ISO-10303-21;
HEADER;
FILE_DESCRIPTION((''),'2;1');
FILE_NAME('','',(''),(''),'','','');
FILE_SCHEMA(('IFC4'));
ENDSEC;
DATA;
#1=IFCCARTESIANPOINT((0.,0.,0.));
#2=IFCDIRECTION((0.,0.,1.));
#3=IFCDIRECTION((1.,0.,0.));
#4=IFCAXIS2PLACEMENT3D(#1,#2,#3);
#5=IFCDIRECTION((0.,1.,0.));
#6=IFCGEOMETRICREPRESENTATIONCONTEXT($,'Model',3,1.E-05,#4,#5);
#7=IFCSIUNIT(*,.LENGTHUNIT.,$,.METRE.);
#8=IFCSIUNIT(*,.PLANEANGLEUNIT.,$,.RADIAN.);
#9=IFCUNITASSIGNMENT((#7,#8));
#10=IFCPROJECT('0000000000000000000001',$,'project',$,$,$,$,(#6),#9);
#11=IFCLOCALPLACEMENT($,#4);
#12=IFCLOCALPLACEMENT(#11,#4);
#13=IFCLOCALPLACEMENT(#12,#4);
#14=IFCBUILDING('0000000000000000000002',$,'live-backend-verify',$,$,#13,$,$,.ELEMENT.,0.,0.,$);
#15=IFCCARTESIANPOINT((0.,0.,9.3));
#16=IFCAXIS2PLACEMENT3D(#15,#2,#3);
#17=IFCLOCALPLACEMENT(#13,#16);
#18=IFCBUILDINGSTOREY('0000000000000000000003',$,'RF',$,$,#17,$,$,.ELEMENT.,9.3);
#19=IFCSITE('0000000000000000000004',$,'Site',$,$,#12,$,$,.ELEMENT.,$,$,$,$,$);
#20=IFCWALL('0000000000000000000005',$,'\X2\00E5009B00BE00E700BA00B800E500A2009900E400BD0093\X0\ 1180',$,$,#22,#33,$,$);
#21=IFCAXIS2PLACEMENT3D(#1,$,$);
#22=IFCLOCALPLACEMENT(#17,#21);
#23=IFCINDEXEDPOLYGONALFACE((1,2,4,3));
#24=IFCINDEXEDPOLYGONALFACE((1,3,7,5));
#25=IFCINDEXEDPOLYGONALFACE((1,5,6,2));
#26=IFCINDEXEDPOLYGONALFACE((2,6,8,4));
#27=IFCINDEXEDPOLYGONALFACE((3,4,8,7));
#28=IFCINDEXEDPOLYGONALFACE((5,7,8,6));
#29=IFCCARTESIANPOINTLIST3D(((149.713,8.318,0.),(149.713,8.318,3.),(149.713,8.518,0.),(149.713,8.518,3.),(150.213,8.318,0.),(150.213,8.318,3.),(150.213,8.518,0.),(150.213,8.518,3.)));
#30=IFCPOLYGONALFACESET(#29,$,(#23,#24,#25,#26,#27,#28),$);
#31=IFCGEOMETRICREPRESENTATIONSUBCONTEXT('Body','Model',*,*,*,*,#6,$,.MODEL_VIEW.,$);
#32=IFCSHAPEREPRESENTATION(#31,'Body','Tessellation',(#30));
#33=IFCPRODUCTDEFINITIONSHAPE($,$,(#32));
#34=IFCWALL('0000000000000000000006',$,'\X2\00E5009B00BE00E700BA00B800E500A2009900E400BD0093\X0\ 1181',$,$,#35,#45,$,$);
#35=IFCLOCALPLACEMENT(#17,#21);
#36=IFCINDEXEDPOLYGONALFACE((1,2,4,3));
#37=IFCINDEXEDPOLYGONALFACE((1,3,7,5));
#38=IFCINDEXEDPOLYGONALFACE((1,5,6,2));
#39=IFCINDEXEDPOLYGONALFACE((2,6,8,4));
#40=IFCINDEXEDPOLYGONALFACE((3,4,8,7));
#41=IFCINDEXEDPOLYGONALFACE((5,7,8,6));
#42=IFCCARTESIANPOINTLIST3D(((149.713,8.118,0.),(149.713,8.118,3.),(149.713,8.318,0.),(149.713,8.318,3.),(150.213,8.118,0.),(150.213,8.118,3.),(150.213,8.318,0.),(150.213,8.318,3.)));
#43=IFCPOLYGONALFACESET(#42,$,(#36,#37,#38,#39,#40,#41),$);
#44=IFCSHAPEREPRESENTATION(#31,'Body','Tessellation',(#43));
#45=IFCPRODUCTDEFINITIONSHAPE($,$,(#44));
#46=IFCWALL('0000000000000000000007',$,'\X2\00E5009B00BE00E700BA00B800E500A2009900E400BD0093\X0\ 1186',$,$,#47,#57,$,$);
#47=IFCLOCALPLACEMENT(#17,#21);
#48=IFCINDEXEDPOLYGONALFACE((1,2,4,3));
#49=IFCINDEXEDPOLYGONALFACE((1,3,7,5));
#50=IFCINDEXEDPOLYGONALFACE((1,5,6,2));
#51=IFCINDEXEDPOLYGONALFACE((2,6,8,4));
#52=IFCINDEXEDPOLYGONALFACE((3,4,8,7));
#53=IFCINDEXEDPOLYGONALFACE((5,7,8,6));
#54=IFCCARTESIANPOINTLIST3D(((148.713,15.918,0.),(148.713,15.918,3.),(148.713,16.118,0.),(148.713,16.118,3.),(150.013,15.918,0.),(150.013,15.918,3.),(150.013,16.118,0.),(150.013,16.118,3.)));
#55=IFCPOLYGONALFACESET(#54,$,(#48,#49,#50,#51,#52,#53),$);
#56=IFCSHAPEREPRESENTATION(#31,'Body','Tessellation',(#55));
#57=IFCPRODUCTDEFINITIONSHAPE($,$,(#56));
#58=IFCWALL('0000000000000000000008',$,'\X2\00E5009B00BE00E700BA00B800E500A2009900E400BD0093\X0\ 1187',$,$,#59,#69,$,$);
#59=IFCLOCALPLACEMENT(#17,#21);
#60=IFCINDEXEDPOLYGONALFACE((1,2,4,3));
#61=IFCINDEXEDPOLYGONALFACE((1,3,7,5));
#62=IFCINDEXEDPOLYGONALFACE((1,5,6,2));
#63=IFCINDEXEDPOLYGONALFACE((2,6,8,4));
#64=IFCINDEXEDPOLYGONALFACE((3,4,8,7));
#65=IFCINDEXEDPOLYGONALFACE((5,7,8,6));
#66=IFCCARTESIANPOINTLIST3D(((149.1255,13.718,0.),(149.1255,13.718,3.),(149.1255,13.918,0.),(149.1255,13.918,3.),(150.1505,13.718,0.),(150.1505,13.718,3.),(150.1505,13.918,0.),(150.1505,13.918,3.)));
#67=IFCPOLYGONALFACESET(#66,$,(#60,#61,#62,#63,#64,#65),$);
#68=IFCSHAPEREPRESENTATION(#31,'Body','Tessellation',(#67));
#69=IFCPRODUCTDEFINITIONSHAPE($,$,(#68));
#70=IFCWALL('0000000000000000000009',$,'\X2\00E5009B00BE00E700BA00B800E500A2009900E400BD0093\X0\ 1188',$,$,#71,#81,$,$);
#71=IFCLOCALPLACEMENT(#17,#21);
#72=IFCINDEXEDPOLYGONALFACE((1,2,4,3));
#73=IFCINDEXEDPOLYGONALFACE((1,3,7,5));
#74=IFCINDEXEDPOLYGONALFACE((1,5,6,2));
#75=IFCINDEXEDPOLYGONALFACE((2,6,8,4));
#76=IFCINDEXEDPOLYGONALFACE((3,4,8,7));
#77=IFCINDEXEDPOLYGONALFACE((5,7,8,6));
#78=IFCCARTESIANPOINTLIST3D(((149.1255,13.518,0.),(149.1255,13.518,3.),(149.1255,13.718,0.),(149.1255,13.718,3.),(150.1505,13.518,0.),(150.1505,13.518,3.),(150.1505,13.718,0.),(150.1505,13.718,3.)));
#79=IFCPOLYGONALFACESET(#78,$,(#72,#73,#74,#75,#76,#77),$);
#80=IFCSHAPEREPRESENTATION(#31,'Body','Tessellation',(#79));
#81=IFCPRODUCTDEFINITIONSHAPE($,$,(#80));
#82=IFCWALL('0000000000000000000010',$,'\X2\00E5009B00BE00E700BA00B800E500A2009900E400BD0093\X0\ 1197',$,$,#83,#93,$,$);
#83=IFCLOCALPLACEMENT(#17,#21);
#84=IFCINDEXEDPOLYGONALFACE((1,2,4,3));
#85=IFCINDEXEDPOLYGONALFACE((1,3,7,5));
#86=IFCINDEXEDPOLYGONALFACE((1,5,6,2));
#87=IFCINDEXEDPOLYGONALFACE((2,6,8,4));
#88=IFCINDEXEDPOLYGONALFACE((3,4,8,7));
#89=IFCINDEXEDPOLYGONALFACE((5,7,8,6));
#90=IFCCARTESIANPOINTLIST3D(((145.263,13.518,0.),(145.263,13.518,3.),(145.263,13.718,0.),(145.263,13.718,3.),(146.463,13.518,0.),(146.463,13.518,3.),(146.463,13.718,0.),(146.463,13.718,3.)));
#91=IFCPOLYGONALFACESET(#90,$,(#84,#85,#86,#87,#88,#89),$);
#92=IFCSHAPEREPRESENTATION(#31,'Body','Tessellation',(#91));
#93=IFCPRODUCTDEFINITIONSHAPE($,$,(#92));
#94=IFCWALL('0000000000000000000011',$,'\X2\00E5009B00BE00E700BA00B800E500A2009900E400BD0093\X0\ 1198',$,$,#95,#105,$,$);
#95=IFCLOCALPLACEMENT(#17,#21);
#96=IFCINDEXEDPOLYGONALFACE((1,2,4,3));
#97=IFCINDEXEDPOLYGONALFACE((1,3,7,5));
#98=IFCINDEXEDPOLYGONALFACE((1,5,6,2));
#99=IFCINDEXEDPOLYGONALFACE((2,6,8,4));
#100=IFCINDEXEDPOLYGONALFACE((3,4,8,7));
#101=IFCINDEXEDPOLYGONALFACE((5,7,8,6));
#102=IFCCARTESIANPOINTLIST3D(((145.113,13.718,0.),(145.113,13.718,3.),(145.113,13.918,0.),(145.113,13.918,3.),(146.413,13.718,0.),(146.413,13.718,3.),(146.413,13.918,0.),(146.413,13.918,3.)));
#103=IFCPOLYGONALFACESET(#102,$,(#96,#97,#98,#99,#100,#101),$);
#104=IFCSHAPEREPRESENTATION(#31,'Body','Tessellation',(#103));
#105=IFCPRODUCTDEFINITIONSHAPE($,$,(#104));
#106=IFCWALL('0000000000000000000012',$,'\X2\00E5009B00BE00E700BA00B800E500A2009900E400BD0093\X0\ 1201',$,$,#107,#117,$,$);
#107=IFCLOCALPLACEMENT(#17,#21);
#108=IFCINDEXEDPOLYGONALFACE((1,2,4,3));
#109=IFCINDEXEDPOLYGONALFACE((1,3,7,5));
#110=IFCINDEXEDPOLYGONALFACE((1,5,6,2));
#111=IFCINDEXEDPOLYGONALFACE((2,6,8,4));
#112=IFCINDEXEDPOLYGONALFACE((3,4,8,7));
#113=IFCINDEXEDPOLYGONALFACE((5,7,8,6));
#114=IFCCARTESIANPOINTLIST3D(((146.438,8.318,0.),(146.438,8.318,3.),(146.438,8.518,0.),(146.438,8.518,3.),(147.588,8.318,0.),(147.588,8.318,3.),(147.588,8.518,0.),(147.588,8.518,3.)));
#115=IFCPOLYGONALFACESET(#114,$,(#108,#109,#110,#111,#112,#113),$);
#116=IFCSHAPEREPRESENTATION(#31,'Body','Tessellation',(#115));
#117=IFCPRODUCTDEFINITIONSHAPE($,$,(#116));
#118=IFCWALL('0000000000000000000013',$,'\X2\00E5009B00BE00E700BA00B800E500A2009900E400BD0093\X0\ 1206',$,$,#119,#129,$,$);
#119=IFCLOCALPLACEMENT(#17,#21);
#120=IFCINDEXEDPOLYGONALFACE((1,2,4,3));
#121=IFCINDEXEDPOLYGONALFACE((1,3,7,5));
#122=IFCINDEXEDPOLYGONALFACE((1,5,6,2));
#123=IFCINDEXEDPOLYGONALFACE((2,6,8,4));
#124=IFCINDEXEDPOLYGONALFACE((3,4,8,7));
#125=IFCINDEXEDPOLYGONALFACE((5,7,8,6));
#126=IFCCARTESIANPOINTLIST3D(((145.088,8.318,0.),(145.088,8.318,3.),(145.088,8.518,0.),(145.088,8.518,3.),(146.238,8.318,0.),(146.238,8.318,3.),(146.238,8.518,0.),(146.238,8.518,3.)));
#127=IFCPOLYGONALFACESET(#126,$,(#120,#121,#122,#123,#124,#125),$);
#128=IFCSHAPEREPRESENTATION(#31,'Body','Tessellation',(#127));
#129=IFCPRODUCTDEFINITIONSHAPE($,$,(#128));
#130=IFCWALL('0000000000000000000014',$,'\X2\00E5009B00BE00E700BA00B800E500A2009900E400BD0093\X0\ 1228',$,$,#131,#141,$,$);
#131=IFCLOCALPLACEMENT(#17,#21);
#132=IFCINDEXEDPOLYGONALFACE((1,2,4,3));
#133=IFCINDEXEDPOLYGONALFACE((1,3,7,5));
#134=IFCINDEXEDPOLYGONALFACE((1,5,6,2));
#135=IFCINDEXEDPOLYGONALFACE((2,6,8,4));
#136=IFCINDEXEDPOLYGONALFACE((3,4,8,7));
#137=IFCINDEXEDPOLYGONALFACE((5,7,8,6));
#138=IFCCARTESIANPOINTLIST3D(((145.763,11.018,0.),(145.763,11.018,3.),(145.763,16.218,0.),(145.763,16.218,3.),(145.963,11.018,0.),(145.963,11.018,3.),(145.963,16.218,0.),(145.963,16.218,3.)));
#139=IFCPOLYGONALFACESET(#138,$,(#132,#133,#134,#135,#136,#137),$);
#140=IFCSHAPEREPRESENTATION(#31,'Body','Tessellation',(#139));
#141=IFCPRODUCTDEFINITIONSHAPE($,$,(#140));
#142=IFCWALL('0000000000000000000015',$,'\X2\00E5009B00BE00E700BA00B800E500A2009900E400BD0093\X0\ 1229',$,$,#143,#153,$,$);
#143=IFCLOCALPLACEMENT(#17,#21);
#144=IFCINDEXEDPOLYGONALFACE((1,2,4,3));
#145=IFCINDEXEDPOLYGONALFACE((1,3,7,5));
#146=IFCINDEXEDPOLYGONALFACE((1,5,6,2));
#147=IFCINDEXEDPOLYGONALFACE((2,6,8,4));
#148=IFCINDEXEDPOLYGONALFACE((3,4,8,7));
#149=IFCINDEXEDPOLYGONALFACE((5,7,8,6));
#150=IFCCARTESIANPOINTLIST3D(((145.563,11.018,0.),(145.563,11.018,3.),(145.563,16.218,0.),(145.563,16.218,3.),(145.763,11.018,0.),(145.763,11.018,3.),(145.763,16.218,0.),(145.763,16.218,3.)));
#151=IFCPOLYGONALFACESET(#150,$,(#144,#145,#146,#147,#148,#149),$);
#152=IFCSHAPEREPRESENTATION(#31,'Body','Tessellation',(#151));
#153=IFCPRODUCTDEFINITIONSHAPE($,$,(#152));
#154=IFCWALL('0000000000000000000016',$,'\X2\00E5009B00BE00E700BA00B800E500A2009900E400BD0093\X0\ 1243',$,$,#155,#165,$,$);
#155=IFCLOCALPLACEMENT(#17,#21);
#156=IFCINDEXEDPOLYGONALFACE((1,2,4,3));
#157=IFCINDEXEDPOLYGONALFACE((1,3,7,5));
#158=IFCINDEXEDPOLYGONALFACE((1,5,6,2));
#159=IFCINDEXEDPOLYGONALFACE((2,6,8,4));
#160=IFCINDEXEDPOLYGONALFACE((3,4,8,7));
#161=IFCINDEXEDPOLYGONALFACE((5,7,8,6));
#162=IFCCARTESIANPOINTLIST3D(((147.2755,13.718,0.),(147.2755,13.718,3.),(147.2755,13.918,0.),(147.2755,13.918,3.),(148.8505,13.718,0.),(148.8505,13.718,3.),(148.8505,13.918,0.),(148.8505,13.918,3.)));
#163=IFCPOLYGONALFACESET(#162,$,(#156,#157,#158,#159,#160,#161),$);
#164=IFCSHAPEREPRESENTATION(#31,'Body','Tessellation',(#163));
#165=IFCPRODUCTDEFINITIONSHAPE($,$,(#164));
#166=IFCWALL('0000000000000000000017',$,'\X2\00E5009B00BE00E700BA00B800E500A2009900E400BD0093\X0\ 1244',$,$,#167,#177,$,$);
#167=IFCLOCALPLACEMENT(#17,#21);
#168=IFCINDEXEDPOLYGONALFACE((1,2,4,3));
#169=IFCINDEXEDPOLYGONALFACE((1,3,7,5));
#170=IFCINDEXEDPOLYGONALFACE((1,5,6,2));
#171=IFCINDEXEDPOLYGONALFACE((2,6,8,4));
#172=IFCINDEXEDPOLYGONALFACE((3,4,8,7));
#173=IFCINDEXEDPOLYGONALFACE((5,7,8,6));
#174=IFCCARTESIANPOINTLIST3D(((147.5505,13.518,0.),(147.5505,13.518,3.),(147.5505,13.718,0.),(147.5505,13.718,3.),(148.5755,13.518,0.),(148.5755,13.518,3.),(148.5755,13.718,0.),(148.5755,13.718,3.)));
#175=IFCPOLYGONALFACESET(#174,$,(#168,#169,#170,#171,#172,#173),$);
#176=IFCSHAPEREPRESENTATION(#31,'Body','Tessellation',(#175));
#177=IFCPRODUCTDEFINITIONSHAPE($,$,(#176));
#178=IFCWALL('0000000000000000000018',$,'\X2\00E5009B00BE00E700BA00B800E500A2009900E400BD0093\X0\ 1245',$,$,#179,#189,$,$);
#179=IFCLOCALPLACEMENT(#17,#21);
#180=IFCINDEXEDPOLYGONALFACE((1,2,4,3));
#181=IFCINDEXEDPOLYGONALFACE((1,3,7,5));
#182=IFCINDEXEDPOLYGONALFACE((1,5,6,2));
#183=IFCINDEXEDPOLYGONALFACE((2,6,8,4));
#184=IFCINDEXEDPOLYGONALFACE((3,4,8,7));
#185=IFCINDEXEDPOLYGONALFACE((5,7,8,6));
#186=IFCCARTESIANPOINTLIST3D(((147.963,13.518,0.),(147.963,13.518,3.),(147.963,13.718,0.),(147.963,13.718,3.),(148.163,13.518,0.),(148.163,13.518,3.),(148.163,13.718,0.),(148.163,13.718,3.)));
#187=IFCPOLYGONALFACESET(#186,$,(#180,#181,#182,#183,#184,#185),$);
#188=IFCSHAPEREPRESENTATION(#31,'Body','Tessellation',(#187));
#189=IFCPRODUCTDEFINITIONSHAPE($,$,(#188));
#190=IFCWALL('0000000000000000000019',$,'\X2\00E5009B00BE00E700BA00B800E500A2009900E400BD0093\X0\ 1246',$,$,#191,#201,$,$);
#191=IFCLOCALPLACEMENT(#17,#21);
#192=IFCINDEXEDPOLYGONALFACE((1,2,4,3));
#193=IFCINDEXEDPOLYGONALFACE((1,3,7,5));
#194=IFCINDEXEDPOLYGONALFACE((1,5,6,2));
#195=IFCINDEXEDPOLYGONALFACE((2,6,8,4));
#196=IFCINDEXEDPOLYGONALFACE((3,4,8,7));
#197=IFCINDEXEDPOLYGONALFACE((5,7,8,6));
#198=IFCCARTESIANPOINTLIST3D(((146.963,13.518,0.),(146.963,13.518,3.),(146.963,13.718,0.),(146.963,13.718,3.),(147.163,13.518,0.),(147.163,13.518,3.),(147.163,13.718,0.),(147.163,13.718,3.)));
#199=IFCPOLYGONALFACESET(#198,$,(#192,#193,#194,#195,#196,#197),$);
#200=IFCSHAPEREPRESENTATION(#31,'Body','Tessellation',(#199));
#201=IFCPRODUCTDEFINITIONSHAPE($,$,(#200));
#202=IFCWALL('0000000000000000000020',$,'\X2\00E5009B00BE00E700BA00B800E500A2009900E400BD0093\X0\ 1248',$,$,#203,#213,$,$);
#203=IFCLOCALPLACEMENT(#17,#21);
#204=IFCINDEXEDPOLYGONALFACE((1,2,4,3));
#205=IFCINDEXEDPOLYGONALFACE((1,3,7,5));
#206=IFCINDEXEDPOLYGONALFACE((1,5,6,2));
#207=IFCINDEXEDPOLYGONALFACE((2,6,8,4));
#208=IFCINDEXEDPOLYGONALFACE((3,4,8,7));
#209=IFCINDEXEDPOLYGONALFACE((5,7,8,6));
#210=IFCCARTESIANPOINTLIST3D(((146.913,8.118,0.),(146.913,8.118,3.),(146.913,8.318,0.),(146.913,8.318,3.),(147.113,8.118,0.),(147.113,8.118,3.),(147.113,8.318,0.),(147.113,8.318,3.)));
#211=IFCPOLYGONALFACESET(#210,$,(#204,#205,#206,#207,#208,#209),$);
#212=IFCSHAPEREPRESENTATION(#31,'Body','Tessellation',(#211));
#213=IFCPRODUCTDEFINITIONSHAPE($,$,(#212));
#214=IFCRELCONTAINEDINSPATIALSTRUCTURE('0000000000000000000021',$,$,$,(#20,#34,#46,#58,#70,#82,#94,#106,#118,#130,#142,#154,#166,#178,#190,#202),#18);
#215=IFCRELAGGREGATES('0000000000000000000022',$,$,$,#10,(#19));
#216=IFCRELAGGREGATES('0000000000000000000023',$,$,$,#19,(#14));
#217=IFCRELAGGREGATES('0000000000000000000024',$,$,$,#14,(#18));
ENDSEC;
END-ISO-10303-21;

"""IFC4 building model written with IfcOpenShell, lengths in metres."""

from ifc_helpers import new_model, si_unit, direction, frame, frame_2d, origin_with_axes, place, context, subcontext, project, spatial, rectangle, extrude, element, save


model = new_model("IFC4")

# Units and contexts
model_context = context("Model", 3, precision=1e-05, world=origin_with_axes(), true_north=direction((0.0, 1.0, 0.0)))
body_context = subcontext(model_context, "Body", "Model", "MODEL_VIEW")
ifc_project = project(units=[si_unit("LENGTHUNIT", "METRE"), si_unit("PLANEANGLEUNIT", "RADIAN")], contexts=[model_context])

# Site, building, storey
placement = place(None, origin_with_axes())
site_placement = place(placement, origin_with_axes())
site = spatial("IfcSite", under=ifc_project, at=site_placement, Name="Site", CompositionType="ELEMENT")
building_placement = place(site_placement, origin_with_axes())
building = spatial("IfcBuilding", under=site, at=building_placement, Name="live-backend-verify", CompositionType="ELEMENT", ElevationOfRefHeight=0.0, ElevationOfTerrain=0.0)
storey_placement = place(building_placement, frame((0.0, 0.0, 9.3), z_axis=(0.0, 0.0, 1.0), x_axis=(1.0, 0.0, 0.0)))
storey = spatial("IfcBuildingStorey", under=building, at=storey_placement, Name="RF", CompositionType="ELEMENT", Elevation=9.3)

# Walls
for number, where, z_axis, x_axis, name in (
    (1, (149.963, 8.418, 0.0), (0.0, 0.0, 1.0), (-1.0, 0.0, 0.0), "å\u009b¾çº¸å¢\u0099ä½\u0093 1180"),
    (2, (149.963, 8.218, 0.0), (0.0, 0.0, 1.0), (-1.0, 0.0, 0.0), "å\u009b¾çº¸å¢\u0099ä½\u0093 1181"),
):
    element("IfcWall", number, at=place(storey_placement, frame(where, z_axis=z_axis, x_axis=x_axis)), inside=storey, Name=name, context=body_context, shape_type="SweptSolid", body=[
        extrude(rectangle(XDim=0.5, YDim=0.2, at=frame_2d((0.0, 0.0), x_axis=(1.0, 0.0, 0.0))), frame((0.0, 0.0, 0.0), z_axis=(0.0, 0.0, 1.0)), (0.0, 0.0, 1.0), 3.0),
    ])
wall_1_placement = place(storey_placement, frame((149.363, 16.018, 0.0), z_axis=(0.0, 0.0, 1.0), x_axis=(1.0, 0.0, 0.0)))
element("IfcWall", 3, at=wall_1_placement, inside=storey, Name="å\u009b¾çº¸å¢\u0099ä½\u0093 1186", context=body_context, shape_type="SweptSolid", body=[
    extrude(rectangle(XDim=1.3, YDim=0.2, at=frame_2d((0.0, 0.0), x_axis=(1.0, 0.0, 0.0))), frame((0.0, 0.0, 0.0), z_axis=(0.0, 0.0, 1.0)), (0.0, 0.0, 1.0), 3.0),
])
for number, where, z_axis, x_axis, name in (
    (4, (149.638, 13.818, 0.0), (0.0, 0.0, 1.0), (1.0, 0.0, 0.0), "å\u009b¾çº¸å¢\u0099ä½\u0093 1187"),
    (5, (149.638, 13.618, 0.0), (0.0, 0.0, 1.0), (1.0, 0.0, 0.0), "å\u009b¾çº¸å¢\u0099ä½\u0093 1188"),
):
    element("IfcWall", number, at=place(storey_placement, frame(where, z_axis=z_axis, x_axis=x_axis)), inside=storey, Name=name, context=body_context, shape_type="SweptSolid", body=[
        extrude(rectangle(XDim=1.025, YDim=0.2, at=frame_2d((0.0, 0.0), x_axis=(1.0, 0.0, 0.0))), frame((0.0, 0.0, 0.0), z_axis=(0.0, 0.0, 1.0)), (0.0, 0.0, 1.0), 3.0),
    ])
wall_2_placement = place(storey_placement, frame((145.863, 13.618, 0.0), z_axis=(0.0, 0.0, 1.0), x_axis=(1.0, 0.0, 0.0)))
element("IfcWall", 6, at=wall_2_placement, inside=storey, Name="å\u009b¾çº¸å¢\u0099ä½\u0093 1197", context=body_context, shape_type="SweptSolid", body=[
    extrude(rectangle(XDim=1.2, YDim=0.2, at=frame_2d((0.0, 0.0), x_axis=(1.0, 0.0, 0.0))), frame((0.0, 0.0, 0.0), z_axis=(0.0, 0.0, 1.0)), (0.0, 0.0, 1.0), 3.0),
])
wall_3_placement = place(storey_placement, frame((145.763, 13.818, 0.0), z_axis=(0.0, 0.0, 1.0), x_axis=(1.0, 0.0, 0.0)))
element("IfcWall", 7, at=wall_3_placement, inside=storey, Name="å\u009b¾çº¸å¢\u0099ä½\u0093 1198", context=body_context, shape_type="SweptSolid", body=[
    extrude(rectangle(XDim=1.3, YDim=0.2, at=frame_2d((0.0, 0.0), x_axis=(1.0, 0.0, 0.0))), frame((0.0, 0.0, 0.0), z_axis=(0.0, 0.0, 1.0)), (0.0, 0.0, 1.0), 3.0),
])
for number, where, z_axis, x_axis, name in (
    (8, (147.013, 8.418, 0.0), (0.0, 0.0, 1.0), (-1.0, 0.0, 0.0), "å\u009b¾çº¸å¢\u0099ä½\u0093 1201"),
    (9, (145.663, 8.418, 0.0), (0.0, 0.0, 1.0), (-1.0, 0.0, 0.0), "å\u009b¾çº¸å¢\u0099ä½\u0093 1206"),
):
    element("IfcWall", number, at=place(storey_placement, frame(where, z_axis=z_axis, x_axis=x_axis)), inside=storey, Name=name, context=body_context, shape_type="SweptSolid", body=[
        extrude(rectangle(XDim=1.15, YDim=0.2, at=frame_2d((0.0, 0.0), x_axis=(1.0, 0.0, 0.0))), frame((0.0, 0.0, 0.0), z_axis=(0.0, 0.0, 1.0)), (0.0, 0.0, 1.0), 3.0),
    ])
for number, where, z_axis, x_axis, name in (
    (10, (145.863, 13.618, 0.0), (0.0, 0.0, 1.0), (0.0, -1.0, 0.0), "å\u009b¾çº¸å¢\u0099ä½\u0093 1228"),
    (11, (145.663, 13.618, 0.0), (0.0, 0.0, 1.0), (0.0, -1.0, 0.0), "å\u009b¾çº¸å¢\u0099ä½\u0093 1229"),
):
    element("IfcWall", number, at=place(storey_placement, frame(where, z_axis=z_axis, x_axis=x_axis)), inside=storey, Name=name, context=body_context, shape_type="SweptSolid", body=[
        extrude(rectangle(XDim=5.2, YDim=0.2, at=frame_2d((0.0, 0.0), x_axis=(1.0, 0.0, 0.0))), frame((0.0, 0.0, 0.0), z_axis=(0.0, 0.0, 1.0)), (0.0, 0.0, 1.0), 3.0),
    ])
wall_4_placement = place(storey_placement, frame((148.063, 13.818, 0.0), z_axis=(0.0, 0.0, 1.0), x_axis=(1.0, 0.0, 0.0)))
element("IfcWall", 12, at=wall_4_placement, inside=storey, Name="å\u009b¾çº¸å¢\u0099ä½\u0093 1243", context=body_context, shape_type="SweptSolid", body=[
    extrude(rectangle(XDim=1.575, YDim=0.2, at=frame_2d((0.0, 0.0), x_axis=(1.0, 0.0, 0.0))), frame((0.0, 0.0, 0.0), z_axis=(0.0, 0.0, 1.0)), (0.0, 0.0, 1.0), 3.0),
])
wall_5_placement = place(storey_placement, frame((148.063, 13.618, 0.0), z_axis=(0.0, 0.0, 1.0), x_axis=(1.0, 0.0, 0.0)))
element("IfcWall", 13, at=wall_5_placement, inside=storey, Name="å\u009b¾çº¸å¢\u0099ä½\u0093 1244", context=body_context, shape_type="SweptSolid", body=[
    extrude(rectangle(XDim=1.025, YDim=0.2, at=frame_2d((0.0, 0.0), x_axis=(1.0, 0.0, 0.0))), frame((0.0, 0.0, 0.0), z_axis=(0.0, 0.0, 1.0)), (0.0, 0.0, 1.0), 3.0),
])
for number, where, z_axis, x_axis, name in (
    (14, (148.063, 13.618, 0.0), (0.0, 0.0, 1.0), (0.0, 1.0, 0.0), "å\u009b¾çº¸å¢\u0099ä½\u0093 1245"),
    (15, (147.063, 13.618, 0.0), (0.0, 0.0, 1.0), (0.0, 1.0, 0.0), "å\u009b¾çº¸å¢\u0099ä½\u0093 1246"),
    (16, (147.013, 8.218, 0.0), (0.0, 0.0, 1.0), (0.0, 1.0, 0.0), "å\u009b¾çº¸å¢\u0099ä½\u0093 1248"),
):
    element("IfcWall", number, at=place(storey_placement, frame(where, z_axis=z_axis, x_axis=x_axis)), inside=storey, Name=name, context=body_context, shape_type="SweptSolid", body=[
        extrude(rectangle(XDim=0.2, YDim=0.2, at=frame_2d((0.0, 0.0), x_axis=(1.0, 0.0, 0.0))), frame((0.0, 0.0, 0.0), z_axis=(0.0, 0.0, 1.0)), (0.0, 0.0, 1.0), 3.0),
    ])

save(model, "model.ifc")
